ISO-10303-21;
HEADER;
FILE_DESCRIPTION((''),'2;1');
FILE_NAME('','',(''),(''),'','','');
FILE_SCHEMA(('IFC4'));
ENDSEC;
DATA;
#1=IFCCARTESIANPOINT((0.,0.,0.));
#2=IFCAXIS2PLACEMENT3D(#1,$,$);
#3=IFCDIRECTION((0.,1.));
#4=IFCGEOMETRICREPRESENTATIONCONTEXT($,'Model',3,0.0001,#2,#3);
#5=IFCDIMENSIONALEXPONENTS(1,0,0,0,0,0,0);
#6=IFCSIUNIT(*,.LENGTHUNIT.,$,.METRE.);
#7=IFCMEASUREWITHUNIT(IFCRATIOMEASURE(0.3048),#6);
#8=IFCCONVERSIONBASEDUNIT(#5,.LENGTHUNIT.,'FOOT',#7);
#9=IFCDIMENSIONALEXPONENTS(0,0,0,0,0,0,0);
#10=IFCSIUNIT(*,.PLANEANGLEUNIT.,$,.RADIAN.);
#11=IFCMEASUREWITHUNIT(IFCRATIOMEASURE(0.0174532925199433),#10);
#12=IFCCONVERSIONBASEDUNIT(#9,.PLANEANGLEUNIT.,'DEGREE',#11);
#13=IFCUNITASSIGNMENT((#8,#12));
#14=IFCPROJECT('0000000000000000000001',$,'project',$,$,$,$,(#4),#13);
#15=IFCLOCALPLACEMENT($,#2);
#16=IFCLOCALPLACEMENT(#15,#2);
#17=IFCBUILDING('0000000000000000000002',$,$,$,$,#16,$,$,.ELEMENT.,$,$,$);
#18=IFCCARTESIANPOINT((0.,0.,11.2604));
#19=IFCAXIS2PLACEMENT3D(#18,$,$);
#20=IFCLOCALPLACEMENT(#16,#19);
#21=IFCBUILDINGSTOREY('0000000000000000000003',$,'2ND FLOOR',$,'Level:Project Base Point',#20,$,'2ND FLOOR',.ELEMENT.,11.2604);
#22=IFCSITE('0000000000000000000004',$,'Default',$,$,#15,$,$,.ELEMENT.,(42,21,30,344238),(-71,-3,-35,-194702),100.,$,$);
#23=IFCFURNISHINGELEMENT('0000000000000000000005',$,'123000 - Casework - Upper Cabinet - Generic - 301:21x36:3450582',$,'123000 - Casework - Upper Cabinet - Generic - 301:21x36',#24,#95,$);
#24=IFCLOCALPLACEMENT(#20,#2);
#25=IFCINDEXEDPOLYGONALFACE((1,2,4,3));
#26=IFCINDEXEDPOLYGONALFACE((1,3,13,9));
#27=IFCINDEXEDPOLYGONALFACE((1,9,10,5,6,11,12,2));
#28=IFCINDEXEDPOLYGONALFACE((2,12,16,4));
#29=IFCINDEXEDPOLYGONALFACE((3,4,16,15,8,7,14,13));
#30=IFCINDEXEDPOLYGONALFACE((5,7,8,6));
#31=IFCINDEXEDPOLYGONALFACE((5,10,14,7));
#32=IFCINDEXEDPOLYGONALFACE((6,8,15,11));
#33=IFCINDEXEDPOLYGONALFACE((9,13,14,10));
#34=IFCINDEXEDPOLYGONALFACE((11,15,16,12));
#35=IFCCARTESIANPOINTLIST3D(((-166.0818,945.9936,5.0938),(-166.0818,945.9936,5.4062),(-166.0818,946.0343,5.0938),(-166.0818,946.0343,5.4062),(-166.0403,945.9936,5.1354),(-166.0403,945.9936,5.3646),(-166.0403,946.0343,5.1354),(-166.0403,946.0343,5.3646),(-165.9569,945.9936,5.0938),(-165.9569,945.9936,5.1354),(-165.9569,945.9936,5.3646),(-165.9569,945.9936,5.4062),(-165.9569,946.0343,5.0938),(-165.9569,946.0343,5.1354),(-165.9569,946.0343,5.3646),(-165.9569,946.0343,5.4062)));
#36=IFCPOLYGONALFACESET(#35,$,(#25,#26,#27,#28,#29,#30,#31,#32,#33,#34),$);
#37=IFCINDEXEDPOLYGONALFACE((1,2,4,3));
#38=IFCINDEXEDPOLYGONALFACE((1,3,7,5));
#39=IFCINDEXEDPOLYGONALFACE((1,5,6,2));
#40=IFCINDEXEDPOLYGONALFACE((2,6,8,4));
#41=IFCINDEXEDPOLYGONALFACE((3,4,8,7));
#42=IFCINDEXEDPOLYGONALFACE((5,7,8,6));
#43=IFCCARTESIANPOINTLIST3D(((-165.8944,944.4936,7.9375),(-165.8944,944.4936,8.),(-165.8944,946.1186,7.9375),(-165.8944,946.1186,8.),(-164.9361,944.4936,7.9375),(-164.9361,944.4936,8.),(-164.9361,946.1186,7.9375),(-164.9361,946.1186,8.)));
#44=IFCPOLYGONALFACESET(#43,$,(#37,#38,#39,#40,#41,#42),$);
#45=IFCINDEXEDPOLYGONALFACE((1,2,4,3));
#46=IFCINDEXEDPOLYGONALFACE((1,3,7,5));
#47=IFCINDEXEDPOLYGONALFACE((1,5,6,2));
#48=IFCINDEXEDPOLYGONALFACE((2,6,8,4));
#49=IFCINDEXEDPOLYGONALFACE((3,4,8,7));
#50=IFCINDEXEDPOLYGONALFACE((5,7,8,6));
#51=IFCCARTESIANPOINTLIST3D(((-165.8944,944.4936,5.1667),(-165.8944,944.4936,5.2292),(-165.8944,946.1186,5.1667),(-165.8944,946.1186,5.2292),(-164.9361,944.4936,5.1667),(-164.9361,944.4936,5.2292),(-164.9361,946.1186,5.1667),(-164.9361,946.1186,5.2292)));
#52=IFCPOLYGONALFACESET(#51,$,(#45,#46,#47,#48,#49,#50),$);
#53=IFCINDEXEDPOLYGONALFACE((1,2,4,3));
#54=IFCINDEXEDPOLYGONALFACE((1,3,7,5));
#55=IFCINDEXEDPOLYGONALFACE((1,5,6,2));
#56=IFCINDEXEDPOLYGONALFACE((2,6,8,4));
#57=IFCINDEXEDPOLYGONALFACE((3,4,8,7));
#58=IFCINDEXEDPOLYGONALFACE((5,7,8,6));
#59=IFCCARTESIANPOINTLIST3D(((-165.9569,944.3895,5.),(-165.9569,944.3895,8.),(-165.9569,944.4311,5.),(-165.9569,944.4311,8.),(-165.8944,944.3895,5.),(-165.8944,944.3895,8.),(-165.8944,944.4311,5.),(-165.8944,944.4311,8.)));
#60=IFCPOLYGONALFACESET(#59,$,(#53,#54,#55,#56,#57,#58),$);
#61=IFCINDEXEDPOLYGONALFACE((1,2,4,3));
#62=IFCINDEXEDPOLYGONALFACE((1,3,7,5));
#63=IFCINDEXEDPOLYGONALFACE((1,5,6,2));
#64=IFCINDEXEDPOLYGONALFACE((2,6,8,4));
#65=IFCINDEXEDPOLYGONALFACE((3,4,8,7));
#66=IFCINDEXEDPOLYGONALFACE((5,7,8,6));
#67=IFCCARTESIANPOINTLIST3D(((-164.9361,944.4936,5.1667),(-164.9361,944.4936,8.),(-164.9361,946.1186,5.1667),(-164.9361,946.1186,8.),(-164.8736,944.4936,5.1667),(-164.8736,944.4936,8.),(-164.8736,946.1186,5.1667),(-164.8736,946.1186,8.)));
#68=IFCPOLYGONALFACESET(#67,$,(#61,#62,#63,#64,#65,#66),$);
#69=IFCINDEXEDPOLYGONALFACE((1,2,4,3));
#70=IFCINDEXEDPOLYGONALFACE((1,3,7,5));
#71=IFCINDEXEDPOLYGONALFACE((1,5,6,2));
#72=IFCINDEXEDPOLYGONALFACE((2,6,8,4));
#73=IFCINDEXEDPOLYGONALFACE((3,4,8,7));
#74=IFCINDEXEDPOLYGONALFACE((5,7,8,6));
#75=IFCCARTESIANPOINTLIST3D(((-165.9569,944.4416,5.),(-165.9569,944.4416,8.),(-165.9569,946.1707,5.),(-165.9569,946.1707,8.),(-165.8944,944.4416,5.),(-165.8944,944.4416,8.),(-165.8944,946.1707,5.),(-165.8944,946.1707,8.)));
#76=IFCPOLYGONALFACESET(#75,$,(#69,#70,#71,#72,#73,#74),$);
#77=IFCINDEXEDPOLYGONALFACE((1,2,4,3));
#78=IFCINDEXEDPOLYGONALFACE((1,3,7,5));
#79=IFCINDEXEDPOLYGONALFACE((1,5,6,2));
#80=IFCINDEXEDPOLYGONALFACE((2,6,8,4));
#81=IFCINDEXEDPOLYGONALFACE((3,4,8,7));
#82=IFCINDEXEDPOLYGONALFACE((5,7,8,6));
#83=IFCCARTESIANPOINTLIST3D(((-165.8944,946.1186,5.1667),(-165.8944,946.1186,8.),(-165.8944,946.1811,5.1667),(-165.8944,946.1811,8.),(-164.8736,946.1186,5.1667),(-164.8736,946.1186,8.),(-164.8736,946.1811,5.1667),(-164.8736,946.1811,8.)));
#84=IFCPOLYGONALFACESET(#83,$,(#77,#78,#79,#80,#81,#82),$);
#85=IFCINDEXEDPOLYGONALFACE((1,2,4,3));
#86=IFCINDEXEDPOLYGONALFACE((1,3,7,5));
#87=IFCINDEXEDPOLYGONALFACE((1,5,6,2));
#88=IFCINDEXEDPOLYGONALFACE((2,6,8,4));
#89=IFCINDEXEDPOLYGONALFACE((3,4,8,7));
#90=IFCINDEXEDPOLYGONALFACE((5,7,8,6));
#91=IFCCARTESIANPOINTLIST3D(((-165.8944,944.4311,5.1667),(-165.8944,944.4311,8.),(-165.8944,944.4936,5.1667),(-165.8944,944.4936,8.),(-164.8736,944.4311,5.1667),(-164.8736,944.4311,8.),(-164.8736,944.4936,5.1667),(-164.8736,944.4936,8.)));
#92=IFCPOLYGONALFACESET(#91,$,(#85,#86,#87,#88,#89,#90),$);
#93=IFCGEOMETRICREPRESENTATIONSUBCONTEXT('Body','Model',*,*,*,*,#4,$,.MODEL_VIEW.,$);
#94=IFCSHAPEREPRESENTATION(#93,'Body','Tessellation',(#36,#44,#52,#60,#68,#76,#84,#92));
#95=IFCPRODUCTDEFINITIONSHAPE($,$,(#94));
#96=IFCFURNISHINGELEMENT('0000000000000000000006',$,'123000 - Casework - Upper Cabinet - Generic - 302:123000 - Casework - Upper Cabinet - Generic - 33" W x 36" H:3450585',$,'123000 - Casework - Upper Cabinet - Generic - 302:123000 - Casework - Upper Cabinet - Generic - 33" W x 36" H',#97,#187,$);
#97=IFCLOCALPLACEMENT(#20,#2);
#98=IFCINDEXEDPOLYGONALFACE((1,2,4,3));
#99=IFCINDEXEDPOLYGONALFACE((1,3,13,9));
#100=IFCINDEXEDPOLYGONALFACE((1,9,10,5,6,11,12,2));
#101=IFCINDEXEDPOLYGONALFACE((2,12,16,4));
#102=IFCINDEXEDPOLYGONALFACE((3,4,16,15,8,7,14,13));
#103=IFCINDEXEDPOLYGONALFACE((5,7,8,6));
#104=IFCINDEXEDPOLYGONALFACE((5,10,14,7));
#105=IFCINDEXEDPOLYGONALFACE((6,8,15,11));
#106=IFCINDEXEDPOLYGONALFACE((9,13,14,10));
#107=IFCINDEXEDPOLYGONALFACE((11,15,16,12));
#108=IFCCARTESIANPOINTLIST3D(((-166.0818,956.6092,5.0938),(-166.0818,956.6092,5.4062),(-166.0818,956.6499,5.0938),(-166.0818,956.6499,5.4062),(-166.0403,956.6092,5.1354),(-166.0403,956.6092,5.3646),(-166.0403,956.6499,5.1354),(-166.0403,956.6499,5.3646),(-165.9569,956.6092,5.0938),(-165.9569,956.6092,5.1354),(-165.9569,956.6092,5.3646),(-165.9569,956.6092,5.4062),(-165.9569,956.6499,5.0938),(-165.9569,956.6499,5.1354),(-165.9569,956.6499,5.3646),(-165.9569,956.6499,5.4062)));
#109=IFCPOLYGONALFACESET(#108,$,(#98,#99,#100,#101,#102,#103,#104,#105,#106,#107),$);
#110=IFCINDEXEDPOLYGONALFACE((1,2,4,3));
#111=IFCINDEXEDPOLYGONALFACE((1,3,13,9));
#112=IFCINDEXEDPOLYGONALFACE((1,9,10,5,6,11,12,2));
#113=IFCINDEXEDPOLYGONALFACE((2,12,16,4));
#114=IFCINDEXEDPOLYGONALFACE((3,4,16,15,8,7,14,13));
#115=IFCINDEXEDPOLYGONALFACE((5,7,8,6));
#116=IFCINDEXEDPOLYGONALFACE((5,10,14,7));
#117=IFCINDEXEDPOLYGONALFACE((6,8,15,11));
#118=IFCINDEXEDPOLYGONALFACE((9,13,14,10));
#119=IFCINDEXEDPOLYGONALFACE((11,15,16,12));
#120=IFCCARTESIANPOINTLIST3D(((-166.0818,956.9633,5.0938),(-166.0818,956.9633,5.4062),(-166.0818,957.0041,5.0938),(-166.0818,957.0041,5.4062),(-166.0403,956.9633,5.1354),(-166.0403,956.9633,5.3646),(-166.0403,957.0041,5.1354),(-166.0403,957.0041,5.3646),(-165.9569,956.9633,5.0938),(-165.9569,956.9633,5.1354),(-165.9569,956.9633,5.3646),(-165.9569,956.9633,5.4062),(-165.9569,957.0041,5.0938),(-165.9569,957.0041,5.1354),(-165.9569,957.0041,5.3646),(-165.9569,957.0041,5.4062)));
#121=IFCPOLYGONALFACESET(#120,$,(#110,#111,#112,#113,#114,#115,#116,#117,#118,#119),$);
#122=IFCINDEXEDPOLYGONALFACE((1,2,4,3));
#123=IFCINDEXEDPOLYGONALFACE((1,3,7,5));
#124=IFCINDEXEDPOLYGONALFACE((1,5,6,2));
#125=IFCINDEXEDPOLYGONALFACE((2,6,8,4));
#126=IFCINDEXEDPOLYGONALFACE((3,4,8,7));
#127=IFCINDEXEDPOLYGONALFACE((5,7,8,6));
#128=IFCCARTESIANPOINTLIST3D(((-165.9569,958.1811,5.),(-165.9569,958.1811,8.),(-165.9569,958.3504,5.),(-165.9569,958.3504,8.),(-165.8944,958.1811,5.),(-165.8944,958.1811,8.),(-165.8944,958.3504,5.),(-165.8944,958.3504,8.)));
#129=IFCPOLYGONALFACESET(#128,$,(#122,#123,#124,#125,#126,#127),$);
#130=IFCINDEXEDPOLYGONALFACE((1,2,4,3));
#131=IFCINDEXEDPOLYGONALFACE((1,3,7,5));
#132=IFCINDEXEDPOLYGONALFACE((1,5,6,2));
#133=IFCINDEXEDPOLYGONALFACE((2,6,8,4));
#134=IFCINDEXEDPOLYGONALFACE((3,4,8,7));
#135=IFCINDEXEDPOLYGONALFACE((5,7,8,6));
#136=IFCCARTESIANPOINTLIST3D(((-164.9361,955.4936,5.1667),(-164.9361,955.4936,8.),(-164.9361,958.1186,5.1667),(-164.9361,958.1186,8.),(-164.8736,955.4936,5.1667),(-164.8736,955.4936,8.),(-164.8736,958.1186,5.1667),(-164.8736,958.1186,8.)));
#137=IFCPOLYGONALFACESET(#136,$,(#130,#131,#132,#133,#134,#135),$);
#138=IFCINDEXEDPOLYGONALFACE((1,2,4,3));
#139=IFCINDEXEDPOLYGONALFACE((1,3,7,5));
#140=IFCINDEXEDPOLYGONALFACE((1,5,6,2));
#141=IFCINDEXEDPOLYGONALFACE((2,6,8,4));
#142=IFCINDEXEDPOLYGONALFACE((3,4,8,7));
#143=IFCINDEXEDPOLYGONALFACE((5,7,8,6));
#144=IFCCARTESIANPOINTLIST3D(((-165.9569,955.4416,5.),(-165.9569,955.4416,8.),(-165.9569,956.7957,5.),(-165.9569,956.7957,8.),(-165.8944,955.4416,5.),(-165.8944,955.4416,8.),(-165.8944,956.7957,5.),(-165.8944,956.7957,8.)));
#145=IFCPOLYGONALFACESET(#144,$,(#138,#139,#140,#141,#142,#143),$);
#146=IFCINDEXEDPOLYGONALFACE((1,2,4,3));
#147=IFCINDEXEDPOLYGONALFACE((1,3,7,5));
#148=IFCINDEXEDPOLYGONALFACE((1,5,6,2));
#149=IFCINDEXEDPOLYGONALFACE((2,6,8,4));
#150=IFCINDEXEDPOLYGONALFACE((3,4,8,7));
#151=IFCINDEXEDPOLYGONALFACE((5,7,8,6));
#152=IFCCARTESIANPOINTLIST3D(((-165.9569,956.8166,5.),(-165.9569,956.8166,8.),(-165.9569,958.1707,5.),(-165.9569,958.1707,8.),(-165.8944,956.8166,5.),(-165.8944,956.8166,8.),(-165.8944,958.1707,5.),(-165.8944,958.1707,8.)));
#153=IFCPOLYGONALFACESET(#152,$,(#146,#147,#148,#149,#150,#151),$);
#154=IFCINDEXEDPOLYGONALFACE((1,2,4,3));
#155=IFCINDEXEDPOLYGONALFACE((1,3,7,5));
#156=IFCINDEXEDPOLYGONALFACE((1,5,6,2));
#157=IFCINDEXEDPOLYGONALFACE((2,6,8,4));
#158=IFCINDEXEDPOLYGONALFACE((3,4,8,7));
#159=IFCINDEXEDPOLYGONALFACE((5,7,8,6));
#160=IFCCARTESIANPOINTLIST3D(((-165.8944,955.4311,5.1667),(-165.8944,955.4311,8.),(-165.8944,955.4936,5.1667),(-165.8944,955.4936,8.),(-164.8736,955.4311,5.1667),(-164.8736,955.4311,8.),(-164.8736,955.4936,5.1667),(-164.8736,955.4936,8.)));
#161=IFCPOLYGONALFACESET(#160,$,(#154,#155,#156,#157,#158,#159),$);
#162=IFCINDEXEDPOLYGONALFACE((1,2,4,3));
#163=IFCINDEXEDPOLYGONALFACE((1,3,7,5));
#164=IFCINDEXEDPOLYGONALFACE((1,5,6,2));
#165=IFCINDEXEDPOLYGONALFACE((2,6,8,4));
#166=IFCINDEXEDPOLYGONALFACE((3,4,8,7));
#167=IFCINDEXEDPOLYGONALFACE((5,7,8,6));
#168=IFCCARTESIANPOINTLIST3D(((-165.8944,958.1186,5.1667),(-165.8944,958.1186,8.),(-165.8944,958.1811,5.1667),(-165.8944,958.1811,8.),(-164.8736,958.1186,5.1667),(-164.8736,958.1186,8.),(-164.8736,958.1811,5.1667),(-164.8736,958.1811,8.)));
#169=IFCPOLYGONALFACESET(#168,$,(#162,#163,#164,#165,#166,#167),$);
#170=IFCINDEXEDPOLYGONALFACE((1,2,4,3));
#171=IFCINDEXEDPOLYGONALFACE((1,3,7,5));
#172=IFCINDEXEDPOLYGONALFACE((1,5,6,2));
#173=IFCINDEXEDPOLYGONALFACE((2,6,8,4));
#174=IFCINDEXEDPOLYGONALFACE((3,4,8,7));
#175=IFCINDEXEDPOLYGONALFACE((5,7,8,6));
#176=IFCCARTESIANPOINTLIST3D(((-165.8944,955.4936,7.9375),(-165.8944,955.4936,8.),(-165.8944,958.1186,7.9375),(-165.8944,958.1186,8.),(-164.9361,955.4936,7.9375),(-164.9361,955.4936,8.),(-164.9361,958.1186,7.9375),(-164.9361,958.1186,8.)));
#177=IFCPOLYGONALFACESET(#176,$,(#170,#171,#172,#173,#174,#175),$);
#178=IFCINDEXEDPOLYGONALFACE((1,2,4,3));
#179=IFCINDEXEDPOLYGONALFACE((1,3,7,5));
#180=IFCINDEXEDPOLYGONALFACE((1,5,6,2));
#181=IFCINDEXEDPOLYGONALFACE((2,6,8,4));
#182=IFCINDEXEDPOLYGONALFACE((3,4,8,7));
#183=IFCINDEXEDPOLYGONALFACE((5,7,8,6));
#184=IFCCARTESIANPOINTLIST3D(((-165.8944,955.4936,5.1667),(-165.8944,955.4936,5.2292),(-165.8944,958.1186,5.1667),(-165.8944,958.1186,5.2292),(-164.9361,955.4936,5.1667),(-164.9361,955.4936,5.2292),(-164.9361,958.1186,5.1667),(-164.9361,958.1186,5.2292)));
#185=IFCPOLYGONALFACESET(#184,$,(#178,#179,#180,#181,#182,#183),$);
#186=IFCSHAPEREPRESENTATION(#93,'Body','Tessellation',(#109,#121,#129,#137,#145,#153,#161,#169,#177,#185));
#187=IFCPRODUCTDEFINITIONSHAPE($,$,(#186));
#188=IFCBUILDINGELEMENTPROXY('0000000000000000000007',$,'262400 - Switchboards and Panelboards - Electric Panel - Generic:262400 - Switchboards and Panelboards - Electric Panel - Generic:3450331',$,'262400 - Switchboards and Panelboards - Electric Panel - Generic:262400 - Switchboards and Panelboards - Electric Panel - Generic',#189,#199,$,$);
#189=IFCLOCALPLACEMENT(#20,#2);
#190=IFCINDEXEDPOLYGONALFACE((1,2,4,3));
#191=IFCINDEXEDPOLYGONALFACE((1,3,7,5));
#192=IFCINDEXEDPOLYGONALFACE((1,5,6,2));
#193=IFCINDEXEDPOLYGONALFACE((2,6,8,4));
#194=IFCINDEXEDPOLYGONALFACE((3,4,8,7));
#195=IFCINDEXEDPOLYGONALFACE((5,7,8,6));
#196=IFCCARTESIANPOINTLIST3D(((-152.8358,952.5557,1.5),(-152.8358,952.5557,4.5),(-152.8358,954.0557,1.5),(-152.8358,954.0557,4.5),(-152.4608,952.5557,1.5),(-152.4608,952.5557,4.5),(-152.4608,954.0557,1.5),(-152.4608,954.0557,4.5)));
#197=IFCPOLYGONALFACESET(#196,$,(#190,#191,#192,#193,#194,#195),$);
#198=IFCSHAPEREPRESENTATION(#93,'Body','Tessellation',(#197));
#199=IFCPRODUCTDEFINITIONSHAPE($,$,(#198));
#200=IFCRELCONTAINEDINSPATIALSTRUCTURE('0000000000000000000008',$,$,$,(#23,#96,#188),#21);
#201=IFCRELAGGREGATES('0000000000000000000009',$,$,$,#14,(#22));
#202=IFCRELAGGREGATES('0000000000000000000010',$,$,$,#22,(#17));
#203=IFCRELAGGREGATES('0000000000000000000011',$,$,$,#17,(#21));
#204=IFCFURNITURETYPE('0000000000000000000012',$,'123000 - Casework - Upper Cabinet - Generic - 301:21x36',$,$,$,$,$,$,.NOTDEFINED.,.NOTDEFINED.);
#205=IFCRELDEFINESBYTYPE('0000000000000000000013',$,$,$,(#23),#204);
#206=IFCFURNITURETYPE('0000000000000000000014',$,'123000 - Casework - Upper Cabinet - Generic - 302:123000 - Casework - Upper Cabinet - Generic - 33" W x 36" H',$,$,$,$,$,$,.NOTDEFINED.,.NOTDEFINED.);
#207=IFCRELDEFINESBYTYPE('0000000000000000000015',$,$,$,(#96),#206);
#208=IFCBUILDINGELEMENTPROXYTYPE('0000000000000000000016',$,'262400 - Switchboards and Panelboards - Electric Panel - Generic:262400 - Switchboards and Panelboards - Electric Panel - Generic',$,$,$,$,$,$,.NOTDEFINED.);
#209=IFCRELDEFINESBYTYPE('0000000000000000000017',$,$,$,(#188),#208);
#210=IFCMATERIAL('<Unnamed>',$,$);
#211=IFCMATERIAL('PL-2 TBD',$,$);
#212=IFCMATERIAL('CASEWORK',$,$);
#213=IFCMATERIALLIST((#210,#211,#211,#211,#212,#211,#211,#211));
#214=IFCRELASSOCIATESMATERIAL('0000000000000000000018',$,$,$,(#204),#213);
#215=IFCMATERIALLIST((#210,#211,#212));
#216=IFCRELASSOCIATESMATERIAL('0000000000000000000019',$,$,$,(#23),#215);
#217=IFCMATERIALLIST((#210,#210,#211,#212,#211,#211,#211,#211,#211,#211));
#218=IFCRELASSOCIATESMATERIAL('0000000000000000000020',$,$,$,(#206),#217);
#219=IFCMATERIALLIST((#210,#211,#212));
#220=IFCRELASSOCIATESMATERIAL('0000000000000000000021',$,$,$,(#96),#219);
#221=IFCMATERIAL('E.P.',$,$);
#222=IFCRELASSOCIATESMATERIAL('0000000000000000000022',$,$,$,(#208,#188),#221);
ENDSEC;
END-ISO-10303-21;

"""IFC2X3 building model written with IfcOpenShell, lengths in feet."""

from ifc_helpers import new_model, entity, si_unit, converted_unit, direction, frame, frame_2d, origin, origin_2d_with_axis, place, context, subcontext, project, spatial, polyline, rectangle, outline, extrude, source, transform, mapped, material, material_list, type_object, type_shapes, element, save


model = new_model("IFC2X3")

# Units and contexts
model_context = context("Model", 3, precision=0.0001, world=origin(), true_north=direction((0.0, 1.0)))
body_context = subcontext(model_context, "Body", "Model", "MODEL_VIEW")
ifc_project = project(units=[converted_unit("LENGTHUNIT", "FOOT", entity("IfcRatioMeasure", 0.3048), si_unit("LENGTHUNIT", "METRE"), dimensions=[1, 0, 0, 0, 0, 0, 0]), converted_unit("PLANEANGLEUNIT", "DEGREE", entity("IfcRatioMeasure", 0.0174532925199433), si_unit("PLANEANGLEUNIT", "RADIAN"), dimensions=[0, 0, 0, 0, 0, 0, 0])], contexts=[model_context])

# Site, building, storey
site_placement = place(None, origin())
site = spatial("IfcSite", under=ifc_project, at=site_placement, Name="Default", CompositionType="ELEMENT", RefLatitude=(42, 21, 30, 344238), RefLongitude=(-71, -3, -35, -194702), RefElevation=100.0)
building_placement = place(site_placement, origin())
building = spatial("IfcBuilding", under=site, at=building_placement, CompositionType="ELEMENT")
storey_placement = place(building_placement, frame((0.0, 0.0, 11.2604)))
storey = spatial("IfcBuildingStorey", under=building, at=storey_placement, Name="2ND FLOOR", ObjectType="Level:Project Base Point", LongName="2ND FLOOR", CompositionType="ELEMENT", Elevation=11.2604)

# Furnishing elements
ifc_material_1 = material(Name="<Unnamed>")
ifc_material_2 = material(Name="CASEWORK")
ifc_material_3 = material(Name="PL-2 TBD")
ifc_material_list_1 = material_list([ifc_material_1, ifc_material_3, ifc_material_2])
ifc_material_list_2 = material_list([ifc_material_1, ifc_material_3, ifc_material_3, ifc_material_3, ifc_material_2, ifc_material_3, ifc_material_3, ifc_material_3])
furniture_type_1 = type_object("IfcFurnitureType", Name="123000 - Casework - Upper Cabinet - Generic - 301:21x36", material=ifc_material_list_2)
shared_shape_1 = source(origin(), body_context, "Body", "SweptSolid", [
    extrude(outline(polyline([(0.1146, -0.0521), (0.1562, -0.0521), (0.1562, 0.0729), (-0.1562, 0.0729), (-0.1562, -0.0521), (-0.1146, -0.0521), (-0.1146, 0.0313), (0.1146, 0.0313), (0.1146, -0.0521)])), frame((0.1468, 0.0729, 0.25), z_axis=(1.0, 0.0, 0.0), x_axis=(0.0, 0.0, 1.0)), (0.0, 0.0, 1.0), 0.0407),
    extrude(rectangle(XDim=1.625, YDim=0.9583, at=frame_2d((0.0, 0.0), x_axis=(1.0, 0.0))), frame((0.875, 0.6666, 2.9375), z_axis=(0.0, 0.0, 1.0), x_axis=(-1.0, 0.0, 0.0)), (0.0, 0.0, 1.0), 0.0625),
    extrude(rectangle(XDim=1.625, YDim=0.9583, at=frame_2d((0.0, 0.0), x_axis=(1.0, 0.0))), frame((0.875, 0.6666, 0.1667), z_axis=(0.0, 0.0, 1.0), x_axis=(-1.0, 0.0, 0.0)), (0.0, 0.0, 1.0), 0.0625),
    extrude(rectangle(XDim=0.0625, YDim=0.0417, at=frame_2d((0.0, 0.0), x_axis=(1.0, 0.0))), frame((1.7708, 0.1562, 0.0), z_axis=(0.0, 0.0, 1.0), x_axis=(0.0, -1.0, 0.0)), (0.0, 0.0, 1.0), 3.0),
    extrude(rectangle(XDim=0.0625, YDim=1.625, at=origin_2d_with_axis()), frame((0.875, 1.177, 0.1667), z_axis=(0.0, 0.0, 1.0), x_axis=(0.0, 1.0, 0.0)), (0.0, 0.0, 1.0), 2.8333),
    extrude(rectangle(XDim=0.0625, YDim=1.7292, at=frame_2d((0.0, 0.0), x_axis=(1.0, 0.0))), frame((0.875, 0.1562, 0.0), z_axis=(0.0, 0.0, 1.0), x_axis=(0.0, -1.0, 0.0)), (0.0, 0.0, 1.0), 3.0),
    extrude(rectangle(XDim=0.0625, YDim=1.0208, at=origin_2d_with_axis()), frame((0.0312, 0.6979, 0.1667), z_axis=(0.0, 0.0, 1.0), x_axis=(-1.0, 0.0, 0.0)), (0.0, 0.0, 1.0), 2.8333),
    extrude(rectangle(XDim=0.0625, YDim=1.0208, at=origin_2d_with_axis()), frame((1.7188, 0.6979, 0.1667), z_axis=(0.0, 0.0, 1.0), x_axis=(-1.0, 0.0, 0.0)), (0.0, 0.0, 1.0), 2.8333),
])
type_shapes(furniture_type_1, [shared_shape_1])
furnishing_1_placement = place(storey_placement, frame((-166.0818, 946.1811, 5.0), z_axis=(0.0, 0.0, 1.0), x_axis=(0.0, -1.0, 0.0)))
element("IfcFurnishingElement", 1, at=furnishing_1_placement, inside=storey, type_object=furniture_type_1, material=ifc_material_list_1, Name="123000 - Casework - Upper Cabinet - Generic - 301:21x36:3450582", ObjectType="123000 - Casework - Upper Cabinet - Generic - 301:21x36", context=body_context, shape_type="MappedRepresentation", body=[
    mapped(shared_shape_1, transform((0.0, 0.0, 0.0), scale=1.0)),
])
ifc_material_list_3 = material_list([ifc_material_1, ifc_material_3, ifc_material_2])
ifc_material_list_4 = material_list([ifc_material_1, ifc_material_1, ifc_material_3, ifc_material_2, ifc_material_3, ifc_material_3, ifc_material_3, ifc_material_3, ifc_material_3, ifc_material_3])
furniture_type_2 = type_object("IfcFurnitureType", Name="123000 - Casework - Upper Cabinet - Generic - 302:123000 - Casework - Upper Cabinet - Generic - 33\" W x 36\" H", material=ifc_material_list_4)
shared_shape_2 = source(origin(), body_context, "Body", "SweptSolid", [
    extrude(outline(polyline([(-0.0521, -0.1146), (-0.0521, -0.1562), (0.0729, -0.1562), (0.0729, 0.1562), (-0.0521, 0.1562), (-0.0521, 0.1146), (0.0313, 0.1146), (0.0313, -0.1146), (-0.0521, -0.1146)])), frame((1.178, 1.1354, 0.25), z_axis=(-1.0, 0.0, 0.0), x_axis=(0.0, 1.0, 0.0)), (0.0, 0.0, -1.0), 0.0407),
    extrude(outline(polyline([(-0.0521, -0.1146), (-0.0521, -0.1562), (0.0729, -0.1562), (0.0729, 0.1562), (-0.0521, 0.1562), (-0.0521, 0.1146), (0.0313, 0.1146), (0.0313, -0.1146), (-0.0521, -0.1146)])), frame((1.5322, 1.1354, 0.25), z_axis=(-1.0, 0.0, 0.0), x_axis=(0.0, 1.0, 0.0)), (0.0, 0.0, -1.0), 0.0407),
    extrude(rectangle(XDim=0.1693, YDim=0.0625, at=frame_2d((0.0, 0.0), x_axis=(1.0, 0.0))), frame((2.8346, 1.0521, 0.0)), (0.0, 0.0, 1.0), 3.0),
    extrude(rectangle(XDim=2.625, YDim=0.0625, at=frame_2d((0.0, 0.0), x_axis=(1.0, 0.0))), frame((1.375, 0.0313, 0.1667), z_axis=(0.0, 0.0, 1.0), x_axis=(-1.0, 0.0, 0.0)), (0.0, 0.0, 1.0), 2.8333),
    extrude(rectangle(XDim=1.3542, YDim=0.0625, at=origin_2d_with_axis()), frame((0.6875, 1.0521, 0.0)), (0.0, 0.0, 1.0), 3.0),
    extrude(rectangle(XDim=1.3542, YDim=0.0625, at=origin_2d_with_axis()), frame((2.0625, 1.0521, 0.0)), (0.0, 0.0, 1.0), 3.0),
    extrude(rectangle(XDim=1.0208, YDim=0.0625, at=origin_2d_with_axis()), frame((0.0312, 0.5104, 0.1667), z_axis=(0.0, 0.0, 1.0), x_axis=(0.0, 1.0, 0.0)), (0.0, 0.0, 1.0), 2.8333),
    extrude(rectangle(XDim=1.0208, YDim=0.0625, at=frame_2d((0.0, 0.0), x_axis=(1.0, 0.0))), frame((2.7188, 0.5104, 0.1667), z_axis=(0.0, 0.0, 1.0), x_axis=(0.0, 1.0, 0.0)), (0.0, 0.0, 1.0), 2.8333),
    extrude(rectangle(XDim=0.9583, YDim=2.625, at=frame_2d((0.0, 0.0), x_axis=(1.0, 0.0))), frame((1.375, 0.5417, 2.9375), z_axis=(0.0, 0.0, 1.0), x_axis=(0.0, 1.0, 0.0)), (0.0, 0.0, 1.0), 0.0625),
    extrude(rectangle(XDim=0.9583, YDim=2.625, at=frame_2d((0.0, 0.0), x_axis=(1.0, 0.0))), frame((1.375, 0.5417, 0.1667), z_axis=(0.0, 0.0, 1.0), x_axis=(0.0, 1.0, 0.0)), (0.0, 0.0, 1.0), 0.0625),
])
type_shapes(furniture_type_2, [shared_shape_2])
furnishing_2_placement = place(storey_placement, frame((-164.8736, 955.4311, 5.0), z_axis=(0.0, 0.0, 1.0), x_axis=(0.0, 1.0, 0.0)))
element("IfcFurnishingElement", 2, at=furnishing_2_placement, inside=storey, type_object=furniture_type_2, material=ifc_material_list_3, Name="123000 - Casework - Upper Cabinet - Generic - 302:123000 - Casework - Upper Cabinet - Generic - 33\" W x 36\" H:3450585", ObjectType="123000 - Casework - Upper Cabinet - Generic - 302:123000 - Casework - Upper Cabinet - Generic - 33\" W x 36\" H", context=body_context, shape_type="MappedRepresentation", body=[
    mapped(shared_shape_2, transform((0.0, 0.0, 0.0), scale=1.0)),
])

# Building element proxy
ifc_material_4 = material(Name="E.P.")
building_element_proxy_type_1 = type_object("IfcBuildingElementProxyType", Name="262400 - Switchboards and Panelboards - Electric Panel - Generic:262400 - Switchboards and Panelboards - Electric Panel - Generic", PredefinedType="NOTDEFINED", material=ifc_material_4)
shared_shape_3 = source(origin(), body_context, "Body", "SweptSolid", [
    extrude(rectangle(XDim=0.375, YDim=1.5, at=origin_2d_with_axis()), frame((0.75, 0.1875, 0.0), z_axis=(0.0, 0.0, 1.0), x_axis=(0.0, 1.0, 0.0)), (0.0, 0.0, 1.0), 3.0),
])
type_shapes(building_element_proxy_type_1, [shared_shape_3])
proxy_1_placement = place(storey_placement, frame((-152.4608, 952.5557, 1.5), z_axis=(0.0, 0.0, 1.0), x_axis=(0.0, 1.0, 0.0)))
element("IfcBuildingElementProxy", 3, at=proxy_1_placement, inside=storey, type_object=building_element_proxy_type_1, material=ifc_material_4, Name="262400 - Switchboards and Panelboards - Electric Panel - Generic:262400 - Switchboards and Panelboards - Electric Panel - Generic:3450331", ObjectType="262400 - Switchboards and Panelboards - Electric Panel - Generic:262400 - Switchboards and Panelboards - Electric Panel - Generic", context=body_context, shape_type="MappedRepresentation", body=[
    mapped(shared_shape_3, transform((0.0, 0.0, 0.0), scale=1.0)),
])

save(model, "model.ifc")
